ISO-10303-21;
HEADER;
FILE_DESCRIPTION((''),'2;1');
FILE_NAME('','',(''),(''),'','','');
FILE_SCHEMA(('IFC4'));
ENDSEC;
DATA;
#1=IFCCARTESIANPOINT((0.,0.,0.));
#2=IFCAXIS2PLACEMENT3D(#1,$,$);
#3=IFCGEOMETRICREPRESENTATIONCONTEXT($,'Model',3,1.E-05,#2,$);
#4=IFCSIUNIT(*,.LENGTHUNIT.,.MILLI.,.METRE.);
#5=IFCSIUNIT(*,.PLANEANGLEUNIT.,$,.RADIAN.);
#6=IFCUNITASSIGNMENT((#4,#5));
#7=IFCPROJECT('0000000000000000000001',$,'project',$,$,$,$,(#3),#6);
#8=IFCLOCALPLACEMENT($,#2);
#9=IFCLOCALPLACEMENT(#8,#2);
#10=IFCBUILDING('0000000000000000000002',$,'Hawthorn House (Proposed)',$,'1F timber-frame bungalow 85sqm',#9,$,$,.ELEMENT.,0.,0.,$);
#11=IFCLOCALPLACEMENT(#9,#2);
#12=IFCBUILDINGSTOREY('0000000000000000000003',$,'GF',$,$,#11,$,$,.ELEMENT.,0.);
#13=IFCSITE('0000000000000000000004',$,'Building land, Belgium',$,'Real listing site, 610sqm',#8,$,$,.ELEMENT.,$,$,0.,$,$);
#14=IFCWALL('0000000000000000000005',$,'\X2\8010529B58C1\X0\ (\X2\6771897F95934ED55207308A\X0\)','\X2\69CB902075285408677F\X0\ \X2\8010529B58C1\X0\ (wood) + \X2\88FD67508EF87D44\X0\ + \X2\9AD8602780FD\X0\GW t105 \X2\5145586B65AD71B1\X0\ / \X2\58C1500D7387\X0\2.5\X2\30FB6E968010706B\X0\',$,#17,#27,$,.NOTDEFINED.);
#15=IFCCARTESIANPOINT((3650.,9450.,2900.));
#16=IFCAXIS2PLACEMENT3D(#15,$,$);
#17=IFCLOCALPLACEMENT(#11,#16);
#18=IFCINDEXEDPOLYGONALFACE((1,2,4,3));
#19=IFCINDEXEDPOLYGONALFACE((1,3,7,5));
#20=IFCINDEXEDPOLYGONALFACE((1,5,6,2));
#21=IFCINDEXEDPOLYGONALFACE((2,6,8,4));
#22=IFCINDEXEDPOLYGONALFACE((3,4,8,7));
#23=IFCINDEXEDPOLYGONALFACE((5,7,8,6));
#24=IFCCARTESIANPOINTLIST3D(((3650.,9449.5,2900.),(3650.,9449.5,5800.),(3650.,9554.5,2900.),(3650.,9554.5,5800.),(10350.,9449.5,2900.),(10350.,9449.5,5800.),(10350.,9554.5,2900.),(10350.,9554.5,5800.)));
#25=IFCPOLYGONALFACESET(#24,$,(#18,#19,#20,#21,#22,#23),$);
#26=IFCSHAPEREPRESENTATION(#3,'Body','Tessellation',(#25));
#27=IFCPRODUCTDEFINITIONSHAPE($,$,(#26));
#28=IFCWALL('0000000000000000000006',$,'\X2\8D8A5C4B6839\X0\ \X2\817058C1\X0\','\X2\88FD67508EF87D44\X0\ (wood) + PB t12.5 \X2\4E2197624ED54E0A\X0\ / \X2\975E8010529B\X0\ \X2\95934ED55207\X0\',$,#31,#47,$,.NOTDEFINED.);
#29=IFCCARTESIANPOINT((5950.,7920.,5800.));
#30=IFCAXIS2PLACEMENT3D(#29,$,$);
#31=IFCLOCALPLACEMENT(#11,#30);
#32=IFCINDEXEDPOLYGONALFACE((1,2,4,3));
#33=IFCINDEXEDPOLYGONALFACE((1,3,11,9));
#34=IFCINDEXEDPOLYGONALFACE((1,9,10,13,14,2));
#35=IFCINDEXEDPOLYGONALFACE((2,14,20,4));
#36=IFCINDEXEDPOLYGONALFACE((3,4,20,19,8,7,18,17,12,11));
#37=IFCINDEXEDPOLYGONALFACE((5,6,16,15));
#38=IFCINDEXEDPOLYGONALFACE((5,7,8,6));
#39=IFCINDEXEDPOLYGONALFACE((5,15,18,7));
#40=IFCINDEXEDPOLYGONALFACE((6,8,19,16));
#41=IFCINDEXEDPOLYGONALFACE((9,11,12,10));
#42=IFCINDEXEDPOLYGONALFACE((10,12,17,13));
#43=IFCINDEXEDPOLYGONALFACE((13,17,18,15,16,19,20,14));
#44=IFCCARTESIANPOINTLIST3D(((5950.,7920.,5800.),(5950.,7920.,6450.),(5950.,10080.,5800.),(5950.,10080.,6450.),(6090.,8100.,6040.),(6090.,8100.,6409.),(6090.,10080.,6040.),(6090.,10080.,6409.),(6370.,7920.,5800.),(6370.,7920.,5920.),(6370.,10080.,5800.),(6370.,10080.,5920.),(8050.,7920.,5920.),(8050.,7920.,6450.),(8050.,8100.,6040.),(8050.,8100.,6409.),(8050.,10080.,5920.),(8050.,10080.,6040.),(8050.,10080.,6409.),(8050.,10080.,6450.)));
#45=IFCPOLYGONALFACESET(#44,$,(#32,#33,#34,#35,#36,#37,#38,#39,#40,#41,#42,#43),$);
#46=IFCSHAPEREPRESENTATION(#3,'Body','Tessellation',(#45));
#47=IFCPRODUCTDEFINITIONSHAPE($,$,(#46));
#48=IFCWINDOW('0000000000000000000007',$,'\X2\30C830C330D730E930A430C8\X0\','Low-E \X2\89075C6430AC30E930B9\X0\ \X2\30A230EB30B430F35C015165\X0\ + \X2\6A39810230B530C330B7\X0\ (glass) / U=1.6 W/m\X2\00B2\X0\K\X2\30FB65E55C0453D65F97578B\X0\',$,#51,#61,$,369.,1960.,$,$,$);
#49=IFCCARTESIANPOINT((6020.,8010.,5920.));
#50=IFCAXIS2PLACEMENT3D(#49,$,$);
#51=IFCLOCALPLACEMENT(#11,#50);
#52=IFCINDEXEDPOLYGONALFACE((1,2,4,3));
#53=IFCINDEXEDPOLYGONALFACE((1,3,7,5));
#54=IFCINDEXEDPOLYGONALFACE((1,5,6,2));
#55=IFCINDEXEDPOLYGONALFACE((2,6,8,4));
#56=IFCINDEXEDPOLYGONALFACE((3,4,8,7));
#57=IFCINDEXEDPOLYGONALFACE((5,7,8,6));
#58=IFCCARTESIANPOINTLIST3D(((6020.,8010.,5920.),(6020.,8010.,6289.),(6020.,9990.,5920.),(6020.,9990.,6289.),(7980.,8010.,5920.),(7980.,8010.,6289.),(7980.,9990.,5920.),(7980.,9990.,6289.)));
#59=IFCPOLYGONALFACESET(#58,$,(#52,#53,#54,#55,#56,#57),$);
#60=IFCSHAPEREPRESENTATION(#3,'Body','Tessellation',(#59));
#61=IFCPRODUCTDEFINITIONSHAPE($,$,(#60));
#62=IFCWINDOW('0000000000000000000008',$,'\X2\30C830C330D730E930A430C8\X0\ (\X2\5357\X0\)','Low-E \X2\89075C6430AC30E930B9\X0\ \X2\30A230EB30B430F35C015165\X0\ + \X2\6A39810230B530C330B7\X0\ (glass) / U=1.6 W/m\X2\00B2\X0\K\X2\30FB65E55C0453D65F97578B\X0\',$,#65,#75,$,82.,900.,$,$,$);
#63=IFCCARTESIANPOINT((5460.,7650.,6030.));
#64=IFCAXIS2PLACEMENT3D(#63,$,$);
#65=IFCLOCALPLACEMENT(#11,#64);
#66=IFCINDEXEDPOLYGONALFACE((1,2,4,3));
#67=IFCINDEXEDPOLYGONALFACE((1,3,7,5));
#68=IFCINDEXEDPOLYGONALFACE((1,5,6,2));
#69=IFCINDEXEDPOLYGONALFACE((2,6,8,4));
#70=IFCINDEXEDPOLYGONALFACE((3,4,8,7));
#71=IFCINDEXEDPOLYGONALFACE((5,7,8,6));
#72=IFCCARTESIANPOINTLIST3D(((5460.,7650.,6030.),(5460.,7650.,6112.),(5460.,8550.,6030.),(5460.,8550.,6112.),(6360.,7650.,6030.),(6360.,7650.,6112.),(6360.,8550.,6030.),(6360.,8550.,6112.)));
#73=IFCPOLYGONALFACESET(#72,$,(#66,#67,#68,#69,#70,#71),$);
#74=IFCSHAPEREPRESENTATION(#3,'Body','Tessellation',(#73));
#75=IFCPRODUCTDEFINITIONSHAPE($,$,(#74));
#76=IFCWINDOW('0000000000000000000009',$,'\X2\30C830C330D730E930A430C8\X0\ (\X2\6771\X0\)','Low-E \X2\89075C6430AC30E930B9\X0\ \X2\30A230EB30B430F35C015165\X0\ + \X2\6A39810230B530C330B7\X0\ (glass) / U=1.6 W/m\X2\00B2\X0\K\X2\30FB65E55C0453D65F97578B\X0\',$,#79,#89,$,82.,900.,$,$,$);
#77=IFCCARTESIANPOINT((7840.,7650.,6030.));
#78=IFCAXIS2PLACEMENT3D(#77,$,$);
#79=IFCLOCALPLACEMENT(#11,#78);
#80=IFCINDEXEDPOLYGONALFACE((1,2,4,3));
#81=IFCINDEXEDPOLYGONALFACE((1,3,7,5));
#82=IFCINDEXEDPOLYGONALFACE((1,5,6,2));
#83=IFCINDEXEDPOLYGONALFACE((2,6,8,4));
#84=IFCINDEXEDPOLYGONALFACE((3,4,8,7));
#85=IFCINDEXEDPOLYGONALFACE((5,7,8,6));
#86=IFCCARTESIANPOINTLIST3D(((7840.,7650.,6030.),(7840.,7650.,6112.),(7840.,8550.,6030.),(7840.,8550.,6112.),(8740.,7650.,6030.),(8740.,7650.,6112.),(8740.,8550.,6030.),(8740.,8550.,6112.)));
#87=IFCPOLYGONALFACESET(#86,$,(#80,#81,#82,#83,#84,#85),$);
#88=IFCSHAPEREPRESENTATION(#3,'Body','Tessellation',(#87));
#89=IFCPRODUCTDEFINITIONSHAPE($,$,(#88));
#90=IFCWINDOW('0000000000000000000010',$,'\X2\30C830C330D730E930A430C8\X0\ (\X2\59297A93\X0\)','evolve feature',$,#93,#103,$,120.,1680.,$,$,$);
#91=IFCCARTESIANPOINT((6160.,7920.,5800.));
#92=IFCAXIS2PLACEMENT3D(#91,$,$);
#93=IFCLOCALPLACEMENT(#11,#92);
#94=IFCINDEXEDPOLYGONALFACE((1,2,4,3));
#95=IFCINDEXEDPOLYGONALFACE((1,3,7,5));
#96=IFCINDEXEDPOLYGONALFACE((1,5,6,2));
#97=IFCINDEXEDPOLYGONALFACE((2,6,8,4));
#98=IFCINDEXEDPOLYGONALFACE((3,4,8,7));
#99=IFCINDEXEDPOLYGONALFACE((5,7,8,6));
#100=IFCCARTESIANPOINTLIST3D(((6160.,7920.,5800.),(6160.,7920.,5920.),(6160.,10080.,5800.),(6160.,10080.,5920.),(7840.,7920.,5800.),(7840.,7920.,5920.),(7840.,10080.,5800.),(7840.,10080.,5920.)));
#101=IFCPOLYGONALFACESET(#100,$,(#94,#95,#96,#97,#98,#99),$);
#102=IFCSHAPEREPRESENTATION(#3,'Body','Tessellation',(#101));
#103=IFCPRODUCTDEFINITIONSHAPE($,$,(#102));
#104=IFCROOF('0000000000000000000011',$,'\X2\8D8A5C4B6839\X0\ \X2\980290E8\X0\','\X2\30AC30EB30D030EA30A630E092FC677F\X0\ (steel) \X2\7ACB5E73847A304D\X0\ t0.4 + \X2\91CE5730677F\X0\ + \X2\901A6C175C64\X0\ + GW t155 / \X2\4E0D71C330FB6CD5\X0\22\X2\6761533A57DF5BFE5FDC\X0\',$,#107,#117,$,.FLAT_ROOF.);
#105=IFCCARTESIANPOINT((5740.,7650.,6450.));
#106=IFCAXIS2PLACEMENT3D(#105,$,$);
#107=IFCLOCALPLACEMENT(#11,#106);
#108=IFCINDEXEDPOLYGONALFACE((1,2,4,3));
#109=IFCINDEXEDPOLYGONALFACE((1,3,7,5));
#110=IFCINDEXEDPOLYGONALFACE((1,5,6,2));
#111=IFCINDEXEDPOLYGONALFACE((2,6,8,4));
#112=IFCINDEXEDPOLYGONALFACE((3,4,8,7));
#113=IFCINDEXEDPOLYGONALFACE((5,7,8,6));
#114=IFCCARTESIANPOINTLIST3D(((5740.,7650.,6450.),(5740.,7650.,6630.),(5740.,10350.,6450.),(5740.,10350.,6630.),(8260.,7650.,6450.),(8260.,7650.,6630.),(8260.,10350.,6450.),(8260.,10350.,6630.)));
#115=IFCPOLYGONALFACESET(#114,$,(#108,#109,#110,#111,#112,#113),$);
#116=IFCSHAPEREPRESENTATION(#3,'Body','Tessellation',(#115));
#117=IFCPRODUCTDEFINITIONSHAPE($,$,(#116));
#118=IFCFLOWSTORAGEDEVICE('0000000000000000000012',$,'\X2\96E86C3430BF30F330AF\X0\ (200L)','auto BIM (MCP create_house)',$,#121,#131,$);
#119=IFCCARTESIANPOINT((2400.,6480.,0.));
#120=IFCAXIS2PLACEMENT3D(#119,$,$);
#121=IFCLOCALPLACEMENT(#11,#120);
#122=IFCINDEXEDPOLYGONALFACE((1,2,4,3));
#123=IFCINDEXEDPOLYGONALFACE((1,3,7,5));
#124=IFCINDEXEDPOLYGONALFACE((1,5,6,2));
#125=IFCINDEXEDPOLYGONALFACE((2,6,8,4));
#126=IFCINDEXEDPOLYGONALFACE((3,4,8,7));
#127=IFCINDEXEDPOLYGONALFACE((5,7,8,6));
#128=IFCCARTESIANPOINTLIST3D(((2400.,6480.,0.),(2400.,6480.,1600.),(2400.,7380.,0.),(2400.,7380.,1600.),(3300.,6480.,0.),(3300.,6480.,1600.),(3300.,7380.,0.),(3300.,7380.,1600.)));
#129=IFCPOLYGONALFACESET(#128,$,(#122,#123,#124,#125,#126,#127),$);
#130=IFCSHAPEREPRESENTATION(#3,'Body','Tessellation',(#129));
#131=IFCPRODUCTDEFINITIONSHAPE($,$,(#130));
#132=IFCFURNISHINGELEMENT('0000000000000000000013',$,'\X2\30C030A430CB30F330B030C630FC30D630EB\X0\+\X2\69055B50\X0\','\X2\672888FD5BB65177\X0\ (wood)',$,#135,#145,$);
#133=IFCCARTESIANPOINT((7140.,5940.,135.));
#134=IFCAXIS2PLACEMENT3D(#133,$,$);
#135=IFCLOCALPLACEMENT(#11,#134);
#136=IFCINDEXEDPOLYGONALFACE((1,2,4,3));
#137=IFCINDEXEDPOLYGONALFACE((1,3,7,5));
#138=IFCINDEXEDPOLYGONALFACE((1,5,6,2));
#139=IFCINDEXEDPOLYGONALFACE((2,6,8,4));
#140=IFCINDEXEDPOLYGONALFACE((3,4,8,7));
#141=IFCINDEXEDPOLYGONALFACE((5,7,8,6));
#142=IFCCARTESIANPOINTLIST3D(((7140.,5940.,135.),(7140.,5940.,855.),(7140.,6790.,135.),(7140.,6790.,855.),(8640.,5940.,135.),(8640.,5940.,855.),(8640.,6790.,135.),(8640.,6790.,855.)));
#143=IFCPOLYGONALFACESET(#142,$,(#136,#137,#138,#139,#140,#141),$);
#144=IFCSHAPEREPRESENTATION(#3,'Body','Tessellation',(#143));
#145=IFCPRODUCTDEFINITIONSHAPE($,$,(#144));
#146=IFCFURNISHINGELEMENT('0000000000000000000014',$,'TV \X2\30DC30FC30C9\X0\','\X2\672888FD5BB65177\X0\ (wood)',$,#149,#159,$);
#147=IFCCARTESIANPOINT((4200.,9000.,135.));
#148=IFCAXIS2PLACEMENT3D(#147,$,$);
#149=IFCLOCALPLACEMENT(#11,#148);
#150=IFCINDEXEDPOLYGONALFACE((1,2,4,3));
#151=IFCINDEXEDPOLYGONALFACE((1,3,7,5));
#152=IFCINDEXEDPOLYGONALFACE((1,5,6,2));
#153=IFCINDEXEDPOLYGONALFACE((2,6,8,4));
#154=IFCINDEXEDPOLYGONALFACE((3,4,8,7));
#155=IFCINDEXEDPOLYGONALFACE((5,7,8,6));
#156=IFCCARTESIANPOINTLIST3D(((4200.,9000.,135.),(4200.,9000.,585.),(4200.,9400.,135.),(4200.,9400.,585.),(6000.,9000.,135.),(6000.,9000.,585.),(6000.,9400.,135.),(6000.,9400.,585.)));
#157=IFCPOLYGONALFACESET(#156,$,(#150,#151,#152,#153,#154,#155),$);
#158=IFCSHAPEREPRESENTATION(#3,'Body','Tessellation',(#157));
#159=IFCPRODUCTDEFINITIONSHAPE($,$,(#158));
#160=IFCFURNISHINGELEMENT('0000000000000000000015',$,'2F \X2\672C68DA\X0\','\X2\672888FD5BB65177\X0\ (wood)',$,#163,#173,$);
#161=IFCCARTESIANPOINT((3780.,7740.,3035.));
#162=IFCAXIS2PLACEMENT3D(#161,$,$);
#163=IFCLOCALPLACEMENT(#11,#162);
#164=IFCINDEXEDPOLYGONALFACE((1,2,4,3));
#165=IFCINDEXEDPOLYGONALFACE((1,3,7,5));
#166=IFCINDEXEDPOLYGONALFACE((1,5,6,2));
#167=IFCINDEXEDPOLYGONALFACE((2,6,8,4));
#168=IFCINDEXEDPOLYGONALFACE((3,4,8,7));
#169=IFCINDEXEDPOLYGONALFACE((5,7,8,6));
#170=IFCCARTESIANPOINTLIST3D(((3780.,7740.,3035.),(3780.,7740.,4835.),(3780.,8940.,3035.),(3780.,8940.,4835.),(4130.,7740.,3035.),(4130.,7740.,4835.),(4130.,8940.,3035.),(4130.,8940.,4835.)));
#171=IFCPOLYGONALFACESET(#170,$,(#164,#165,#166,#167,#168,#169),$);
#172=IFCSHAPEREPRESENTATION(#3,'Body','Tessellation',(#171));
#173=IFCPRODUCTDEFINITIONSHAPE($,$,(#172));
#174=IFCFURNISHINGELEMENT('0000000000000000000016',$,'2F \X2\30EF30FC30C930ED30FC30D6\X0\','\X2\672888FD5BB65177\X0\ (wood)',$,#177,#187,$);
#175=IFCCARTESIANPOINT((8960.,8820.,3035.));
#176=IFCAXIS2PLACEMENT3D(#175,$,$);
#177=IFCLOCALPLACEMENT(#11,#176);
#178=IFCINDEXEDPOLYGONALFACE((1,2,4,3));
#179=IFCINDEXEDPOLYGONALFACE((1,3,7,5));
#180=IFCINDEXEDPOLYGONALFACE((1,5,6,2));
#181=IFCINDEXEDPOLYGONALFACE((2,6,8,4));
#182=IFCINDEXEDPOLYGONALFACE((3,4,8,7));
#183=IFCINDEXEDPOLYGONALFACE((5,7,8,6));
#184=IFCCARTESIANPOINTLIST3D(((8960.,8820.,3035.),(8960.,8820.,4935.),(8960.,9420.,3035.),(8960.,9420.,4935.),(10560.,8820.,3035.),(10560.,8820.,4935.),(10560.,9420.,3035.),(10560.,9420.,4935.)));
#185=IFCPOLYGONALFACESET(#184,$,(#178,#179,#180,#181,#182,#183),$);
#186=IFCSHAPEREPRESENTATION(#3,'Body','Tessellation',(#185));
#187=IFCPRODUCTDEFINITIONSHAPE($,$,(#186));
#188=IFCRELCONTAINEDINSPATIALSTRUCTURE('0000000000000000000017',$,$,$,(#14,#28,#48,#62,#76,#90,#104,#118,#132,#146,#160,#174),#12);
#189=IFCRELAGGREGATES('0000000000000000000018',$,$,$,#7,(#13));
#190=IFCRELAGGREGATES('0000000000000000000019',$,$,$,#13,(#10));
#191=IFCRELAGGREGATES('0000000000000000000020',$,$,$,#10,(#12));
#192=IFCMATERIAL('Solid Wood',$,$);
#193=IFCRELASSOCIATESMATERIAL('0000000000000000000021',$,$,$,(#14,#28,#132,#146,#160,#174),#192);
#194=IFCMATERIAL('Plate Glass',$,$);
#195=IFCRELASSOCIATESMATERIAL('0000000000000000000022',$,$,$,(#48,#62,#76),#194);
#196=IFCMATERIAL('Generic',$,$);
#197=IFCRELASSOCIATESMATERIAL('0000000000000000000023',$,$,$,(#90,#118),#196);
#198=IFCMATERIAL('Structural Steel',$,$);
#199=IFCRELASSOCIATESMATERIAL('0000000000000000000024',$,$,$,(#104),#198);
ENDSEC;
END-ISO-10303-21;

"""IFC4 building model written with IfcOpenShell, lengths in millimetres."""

from ifc_helpers import new_model, si_unit, frame, frame_2d, origin, place, context, project, spatial, rectangle, extrude, material, element, fill, save


model = new_model("IFC4")

# Units and contexts
model_context = context("Model", 3, precision=1e-05, world=origin())
ifc_project = project(units=[si_unit("LENGTHUNIT", "METRE", prefix="MILLI"), si_unit("PLANEANGLEUNIT", "RADIAN")], contexts=[model_context])

# Site, building, storey
site_placement = place(None, origin())
site = spatial("IfcSite", under=ifc_project, at=site_placement, Name="Building land, Belgium", ObjectType="Real listing site, 610sqm", CompositionType="ELEMENT", RefElevation=0.0)
building_placement = place(site_placement, origin())
building = spatial("IfcBuilding", under=site, at=building_placement, Name="Hawthorn House (Proposed)", ObjectType="1F timber-frame bungalow 85sqm", CompositionType="ELEMENT", ElevationOfRefHeight=0.0, ElevationOfTerrain=0.0)
storey_placement = place(building_placement, origin())
storey = spatial("IfcBuildingStorey", under=building, at=storey_placement, Name="GF", CompositionType="ELEMENT", Elevation=0.0)

# Wall
ifc_material_1 = material(Name="Solid Wood")
wall_1_placement = place(storey_placement, frame((3650.0, 9450.0, 2900.0)))
element("IfcWall", 1, at=wall_1_placement, inside=storey, material=ifc_material_1, Name="耐力壁 (東西間仕切り)", Description="構造用合板 耐力壁 (wood) + 製材軸組 + 高性能GW t105 充填断熱 / 壁倍率2.5・準耐火", PredefinedType="NOTDEFINED", context=model_context, shape_type="SweptSolid", body=[
    extrude(rectangle(XDim=6700.0, YDim=105.0, at=frame_2d((3350.0, 52.0))), frame((3650.0, 9450.0, 2900.0)), (0.0, 0.0, 1.0), 2900.0),
])

# Wall, openings, windows
wall_2_placement = place(storey_placement, frame((5950.0, 7920.0, 5800.0)))
wall_2 = element("IfcWall", 2, at=wall_2_placement, inside=storey, material=ifc_material_1, Name="越屋根 腰壁", Description="製材軸組 (wood) + PB t12.5 両面仕上 / 非耐力 間仕切", PredefinedType="NOTDEFINED", context=model_context, shape_type="SweptSolid", body=[
    extrude(rectangle(XDim=2100.0, YDim=2160.0, at=frame_2d((1050.0, 1080.0))), frame((5950.0, 7920.0, 5800.0)), (0.0, 0.0, 1.0), 650.0),
])
opening_1_placement = place(storey_placement, frame((6020.0, 8010.0, 5920.0)))
opening_1 = element("IfcOpeningElement", 3, at=opening_1_placement, cuts=wall_2, PredefinedType="NOTDEFINED", context=model_context, shape_type="SweptSolid", body=[
    extrude(rectangle(XDim=1960.0, YDim=1980.0, at=frame_2d((980.0, 990.0))), frame((6020.0, 8010.0, 5920.0)), (0.0, 0.0, 1.0), 369.0),
])
opening_2_placement = place(storey_placement, frame((5460.0, 7650.0, 6030.0)))
opening_2 = element("IfcOpeningElement", 4, at=opening_2_placement, cuts=wall_2, PredefinedType="NOTDEFINED", context=model_context, shape_type="SweptSolid", body=[
    extrude(rectangle(XDim=900.0, YDim=900.0, at=frame_2d((450.0, 450.0))), frame((5460.0, 7650.0, 6030.0)), (0.0, 0.0, 1.0), 82.0),
])
opening_3_placement = place(storey_placement, frame((7840.0, 7650.0, 6030.0)))
opening_3 = element("IfcOpeningElement", 5, at=opening_3_placement, cuts=wall_2, PredefinedType="NOTDEFINED", context=model_context, shape_type="SweptSolid", body=[
    extrude(rectangle(XDim=900.0, YDim=900.0, at=frame_2d((450.0, 450.0))), frame((7840.0, 7650.0, 6030.0)), (0.0, 0.0, 1.0), 82.0),
])
opening_4_placement = place(storey_placement, frame((6160.0, 7920.0, 5800.0)))
opening_4 = element("IfcOpeningElement", 6, at=opening_4_placement, cuts=wall_2, PredefinedType="NOTDEFINED", context=model_context, shape_type="SweptSolid", body=[
    extrude(rectangle(XDim=1680.0, YDim=2160.0, at=frame_2d((840.0, 1080.0))), frame((6160.0, 7920.0, 5800.0)), (0.0, 0.0, 1.0), 120.0),
])
ifc_material_2 = material(Name="Plate Glass")
window_1_placement = place(storey_placement, frame((6020.0, 8010.0, 5920.0)))
window_1 = element("IfcWindow", 7, at=window_1_placement, inside=storey, material=ifc_material_2, Name="トップライト", Description="Low-E 複層ガラス アルゴン封入 + 樹脂サッシ (glass) / U=1.6 W/m²K・日射取得型", OverallHeight=369.0, OverallWidth=1960.0, context=model_context, shape_type="SweptSolid", body=[
    extrude(rectangle(XDim=1960.0, YDim=1980.0, at=frame_2d((980.0, 990.0))), frame((6020.0, 8010.0, 5920.0)), (0.0, 0.0, 1.0), 369.0),
])
fill(opening_1, window_1)
window_2_placement = place(storey_placement, frame((5460.0, 7650.0, 6030.0)))
window_2 = element("IfcWindow", 8, at=window_2_placement, inside=storey, material=ifc_material_2, Name="トップライト (南)", Description="Low-E 複層ガラス アルゴン封入 + 樹脂サッシ (glass) / U=1.6 W/m²K・日射取得型", OverallHeight=82.0, OverallWidth=900.0, context=model_context, shape_type="SweptSolid", body=[
    extrude(rectangle(XDim=900.0, YDim=900.0, at=frame_2d((450.0, 450.0))), frame((5460.0, 7650.0, 6030.0)), (0.0, 0.0, 1.0), 82.0),
])
fill(opening_2, window_2)
window_3_placement = place(storey_placement, frame((7840.0, 7650.0, 6030.0)))
window_3 = element("IfcWindow", 9, at=window_3_placement, inside=storey, material=ifc_material_2, Name="トップライト (東)", Description="Low-E 複層ガラス アルゴン封入 + 樹脂サッシ (glass) / U=1.6 W/m²K・日射取得型", OverallHeight=82.0, OverallWidth=900.0, context=model_context, shape_type="SweptSolid", body=[
    extrude(rectangle(XDim=900.0, YDim=900.0, at=frame_2d((450.0, 450.0))), frame((7840.0, 7650.0, 6030.0)), (0.0, 0.0, 1.0), 82.0),
])
fill(opening_3, window_3)
ifc_material_3 = material(Name="Generic")
window_4_placement = place(storey_placement, frame((6160.0, 7920.0, 5800.0)))
window_4 = element("IfcWindow", 10, at=window_4_placement, inside=storey, material=ifc_material_3, Name="トップライト (天窓)", Description="evolve feature", OverallHeight=120.0, OverallWidth=1680.0, context=model_context, shape_type="SweptSolid", body=[
    extrude(rectangle(XDim=1680.0, YDim=2160.0, at=frame_2d((840.0, 1080.0))), frame((6160.0, 7920.0, 5800.0)), (0.0, 0.0, 1.0), 120.0),
])
fill(opening_4, window_4)

# Roof
ifc_material_4 = material(Name="Structural Steel")
roof_placement = place(storey_placement, frame((5740.0, 7650.0, 6450.0)))
element("IfcRoof", 11, at=roof_placement, inside=storey, material=ifc_material_4, Name="越屋根 頂部", Description="ガルバリウム鋼板 (steel) 立平葺き t0.4 + 野地板 + 通気層 + GW t155 / 不燃・法22条区域対応", PredefinedType="FLAT_ROOF", context=model_context, shape_type="SweptSolid", body=[
    extrude(rectangle(XDim=2520.0, YDim=2700.0, at=frame_2d((1260.0, 1350.0))), frame((5740.0, 7650.0, 6450.0)), (0.0, 0.0, 1.0), 180.0),
])

# Flow storage device
flow_storage_device_placement = place(storey_placement, frame((2400.0, 6480.0, 0.0)))
element("IfcFlowStorageDevice", 12, at=flow_storage_device_placement, inside=storey, material=ifc_material_3, Name="雨水タンク (200L)", Description="auto BIM (MCP create_house)", context=model_context, shape_type="SweptSolid", body=[
    extrude(rectangle(XDim=900.0, YDim=900.0, at=frame_2d((450.0, 450.0))), frame((2400.0, 6480.0, 0.0)), (0.0, 0.0, 1.0), 1600.0),
])

# Furnishing elements
furnishing_1_placement = place(storey_placement, frame((7140.0, 5940.0, 135.0)))
element("IfcFurnishingElement", 13, at=furnishing_1_placement, inside=storey, material=ifc_material_1, Name="ダイニングテーブル+椅子", Description="木製家具 (wood)", context=model_context, shape_type="SweptSolid", body=[
    extrude(rectangle(XDim=1500.0, YDim=850.0, at=frame_2d((750.0, 425.0))), frame((7140.0, 5940.0, 135.0)), (0.0, 0.0, 1.0), 720.0),
])
furnishing_2_placement = place(storey_placement, frame((4200.0, 9000.0, 135.0)))
element("IfcFurnishingElement", 14, at=furnishing_2_placement, inside=storey, material=ifc_material_1, Name="TV ボード", Description="木製家具 (wood)", context=model_context, shape_type="SweptSolid", body=[
    extrude(rectangle(XDim=1800.0, YDim=400.0, at=frame_2d((900.0, 200.0))), frame((4200.0, 9000.0, 135.0)), (0.0, 0.0, 1.0), 450.0),
])
furnishing_3_placement = place(storey_placement, frame((3780.0, 7740.0, 3035.0)))
element("IfcFurnishingElement", 15, at=furnishing_3_placement, inside=storey, material=ifc_material_1, Name="2F 本棚", Description="木製家具 (wood)", context=model_context, shape_type="SweptSolid", body=[
    extrude(rectangle(XDim=350.0, YDim=1200.0, at=frame_2d((175.0, 600.0))), frame((3780.0, 7740.0, 3035.0)), (0.0, 0.0, 1.0), 1800.0),
])
furnishing_4_placement = place(storey_placement, frame((8960.0, 8820.0, 3035.0)))
element("IfcFurnishingElement", 16, at=furnishing_4_placement, inside=storey, material=ifc_material_1, Name="2F ワードローブ", Description="木製家具 (wood)", context=model_context, shape_type="SweptSolid", body=[
    extrude(rectangle(XDim=1600.0, YDim=600.0, at=frame_2d((800.0, 300.0))), frame((8960.0, 8820.0, 3035.0)), (0.0, 0.0, 1.0), 1900.0),
])

save(model, "model.ifc")
